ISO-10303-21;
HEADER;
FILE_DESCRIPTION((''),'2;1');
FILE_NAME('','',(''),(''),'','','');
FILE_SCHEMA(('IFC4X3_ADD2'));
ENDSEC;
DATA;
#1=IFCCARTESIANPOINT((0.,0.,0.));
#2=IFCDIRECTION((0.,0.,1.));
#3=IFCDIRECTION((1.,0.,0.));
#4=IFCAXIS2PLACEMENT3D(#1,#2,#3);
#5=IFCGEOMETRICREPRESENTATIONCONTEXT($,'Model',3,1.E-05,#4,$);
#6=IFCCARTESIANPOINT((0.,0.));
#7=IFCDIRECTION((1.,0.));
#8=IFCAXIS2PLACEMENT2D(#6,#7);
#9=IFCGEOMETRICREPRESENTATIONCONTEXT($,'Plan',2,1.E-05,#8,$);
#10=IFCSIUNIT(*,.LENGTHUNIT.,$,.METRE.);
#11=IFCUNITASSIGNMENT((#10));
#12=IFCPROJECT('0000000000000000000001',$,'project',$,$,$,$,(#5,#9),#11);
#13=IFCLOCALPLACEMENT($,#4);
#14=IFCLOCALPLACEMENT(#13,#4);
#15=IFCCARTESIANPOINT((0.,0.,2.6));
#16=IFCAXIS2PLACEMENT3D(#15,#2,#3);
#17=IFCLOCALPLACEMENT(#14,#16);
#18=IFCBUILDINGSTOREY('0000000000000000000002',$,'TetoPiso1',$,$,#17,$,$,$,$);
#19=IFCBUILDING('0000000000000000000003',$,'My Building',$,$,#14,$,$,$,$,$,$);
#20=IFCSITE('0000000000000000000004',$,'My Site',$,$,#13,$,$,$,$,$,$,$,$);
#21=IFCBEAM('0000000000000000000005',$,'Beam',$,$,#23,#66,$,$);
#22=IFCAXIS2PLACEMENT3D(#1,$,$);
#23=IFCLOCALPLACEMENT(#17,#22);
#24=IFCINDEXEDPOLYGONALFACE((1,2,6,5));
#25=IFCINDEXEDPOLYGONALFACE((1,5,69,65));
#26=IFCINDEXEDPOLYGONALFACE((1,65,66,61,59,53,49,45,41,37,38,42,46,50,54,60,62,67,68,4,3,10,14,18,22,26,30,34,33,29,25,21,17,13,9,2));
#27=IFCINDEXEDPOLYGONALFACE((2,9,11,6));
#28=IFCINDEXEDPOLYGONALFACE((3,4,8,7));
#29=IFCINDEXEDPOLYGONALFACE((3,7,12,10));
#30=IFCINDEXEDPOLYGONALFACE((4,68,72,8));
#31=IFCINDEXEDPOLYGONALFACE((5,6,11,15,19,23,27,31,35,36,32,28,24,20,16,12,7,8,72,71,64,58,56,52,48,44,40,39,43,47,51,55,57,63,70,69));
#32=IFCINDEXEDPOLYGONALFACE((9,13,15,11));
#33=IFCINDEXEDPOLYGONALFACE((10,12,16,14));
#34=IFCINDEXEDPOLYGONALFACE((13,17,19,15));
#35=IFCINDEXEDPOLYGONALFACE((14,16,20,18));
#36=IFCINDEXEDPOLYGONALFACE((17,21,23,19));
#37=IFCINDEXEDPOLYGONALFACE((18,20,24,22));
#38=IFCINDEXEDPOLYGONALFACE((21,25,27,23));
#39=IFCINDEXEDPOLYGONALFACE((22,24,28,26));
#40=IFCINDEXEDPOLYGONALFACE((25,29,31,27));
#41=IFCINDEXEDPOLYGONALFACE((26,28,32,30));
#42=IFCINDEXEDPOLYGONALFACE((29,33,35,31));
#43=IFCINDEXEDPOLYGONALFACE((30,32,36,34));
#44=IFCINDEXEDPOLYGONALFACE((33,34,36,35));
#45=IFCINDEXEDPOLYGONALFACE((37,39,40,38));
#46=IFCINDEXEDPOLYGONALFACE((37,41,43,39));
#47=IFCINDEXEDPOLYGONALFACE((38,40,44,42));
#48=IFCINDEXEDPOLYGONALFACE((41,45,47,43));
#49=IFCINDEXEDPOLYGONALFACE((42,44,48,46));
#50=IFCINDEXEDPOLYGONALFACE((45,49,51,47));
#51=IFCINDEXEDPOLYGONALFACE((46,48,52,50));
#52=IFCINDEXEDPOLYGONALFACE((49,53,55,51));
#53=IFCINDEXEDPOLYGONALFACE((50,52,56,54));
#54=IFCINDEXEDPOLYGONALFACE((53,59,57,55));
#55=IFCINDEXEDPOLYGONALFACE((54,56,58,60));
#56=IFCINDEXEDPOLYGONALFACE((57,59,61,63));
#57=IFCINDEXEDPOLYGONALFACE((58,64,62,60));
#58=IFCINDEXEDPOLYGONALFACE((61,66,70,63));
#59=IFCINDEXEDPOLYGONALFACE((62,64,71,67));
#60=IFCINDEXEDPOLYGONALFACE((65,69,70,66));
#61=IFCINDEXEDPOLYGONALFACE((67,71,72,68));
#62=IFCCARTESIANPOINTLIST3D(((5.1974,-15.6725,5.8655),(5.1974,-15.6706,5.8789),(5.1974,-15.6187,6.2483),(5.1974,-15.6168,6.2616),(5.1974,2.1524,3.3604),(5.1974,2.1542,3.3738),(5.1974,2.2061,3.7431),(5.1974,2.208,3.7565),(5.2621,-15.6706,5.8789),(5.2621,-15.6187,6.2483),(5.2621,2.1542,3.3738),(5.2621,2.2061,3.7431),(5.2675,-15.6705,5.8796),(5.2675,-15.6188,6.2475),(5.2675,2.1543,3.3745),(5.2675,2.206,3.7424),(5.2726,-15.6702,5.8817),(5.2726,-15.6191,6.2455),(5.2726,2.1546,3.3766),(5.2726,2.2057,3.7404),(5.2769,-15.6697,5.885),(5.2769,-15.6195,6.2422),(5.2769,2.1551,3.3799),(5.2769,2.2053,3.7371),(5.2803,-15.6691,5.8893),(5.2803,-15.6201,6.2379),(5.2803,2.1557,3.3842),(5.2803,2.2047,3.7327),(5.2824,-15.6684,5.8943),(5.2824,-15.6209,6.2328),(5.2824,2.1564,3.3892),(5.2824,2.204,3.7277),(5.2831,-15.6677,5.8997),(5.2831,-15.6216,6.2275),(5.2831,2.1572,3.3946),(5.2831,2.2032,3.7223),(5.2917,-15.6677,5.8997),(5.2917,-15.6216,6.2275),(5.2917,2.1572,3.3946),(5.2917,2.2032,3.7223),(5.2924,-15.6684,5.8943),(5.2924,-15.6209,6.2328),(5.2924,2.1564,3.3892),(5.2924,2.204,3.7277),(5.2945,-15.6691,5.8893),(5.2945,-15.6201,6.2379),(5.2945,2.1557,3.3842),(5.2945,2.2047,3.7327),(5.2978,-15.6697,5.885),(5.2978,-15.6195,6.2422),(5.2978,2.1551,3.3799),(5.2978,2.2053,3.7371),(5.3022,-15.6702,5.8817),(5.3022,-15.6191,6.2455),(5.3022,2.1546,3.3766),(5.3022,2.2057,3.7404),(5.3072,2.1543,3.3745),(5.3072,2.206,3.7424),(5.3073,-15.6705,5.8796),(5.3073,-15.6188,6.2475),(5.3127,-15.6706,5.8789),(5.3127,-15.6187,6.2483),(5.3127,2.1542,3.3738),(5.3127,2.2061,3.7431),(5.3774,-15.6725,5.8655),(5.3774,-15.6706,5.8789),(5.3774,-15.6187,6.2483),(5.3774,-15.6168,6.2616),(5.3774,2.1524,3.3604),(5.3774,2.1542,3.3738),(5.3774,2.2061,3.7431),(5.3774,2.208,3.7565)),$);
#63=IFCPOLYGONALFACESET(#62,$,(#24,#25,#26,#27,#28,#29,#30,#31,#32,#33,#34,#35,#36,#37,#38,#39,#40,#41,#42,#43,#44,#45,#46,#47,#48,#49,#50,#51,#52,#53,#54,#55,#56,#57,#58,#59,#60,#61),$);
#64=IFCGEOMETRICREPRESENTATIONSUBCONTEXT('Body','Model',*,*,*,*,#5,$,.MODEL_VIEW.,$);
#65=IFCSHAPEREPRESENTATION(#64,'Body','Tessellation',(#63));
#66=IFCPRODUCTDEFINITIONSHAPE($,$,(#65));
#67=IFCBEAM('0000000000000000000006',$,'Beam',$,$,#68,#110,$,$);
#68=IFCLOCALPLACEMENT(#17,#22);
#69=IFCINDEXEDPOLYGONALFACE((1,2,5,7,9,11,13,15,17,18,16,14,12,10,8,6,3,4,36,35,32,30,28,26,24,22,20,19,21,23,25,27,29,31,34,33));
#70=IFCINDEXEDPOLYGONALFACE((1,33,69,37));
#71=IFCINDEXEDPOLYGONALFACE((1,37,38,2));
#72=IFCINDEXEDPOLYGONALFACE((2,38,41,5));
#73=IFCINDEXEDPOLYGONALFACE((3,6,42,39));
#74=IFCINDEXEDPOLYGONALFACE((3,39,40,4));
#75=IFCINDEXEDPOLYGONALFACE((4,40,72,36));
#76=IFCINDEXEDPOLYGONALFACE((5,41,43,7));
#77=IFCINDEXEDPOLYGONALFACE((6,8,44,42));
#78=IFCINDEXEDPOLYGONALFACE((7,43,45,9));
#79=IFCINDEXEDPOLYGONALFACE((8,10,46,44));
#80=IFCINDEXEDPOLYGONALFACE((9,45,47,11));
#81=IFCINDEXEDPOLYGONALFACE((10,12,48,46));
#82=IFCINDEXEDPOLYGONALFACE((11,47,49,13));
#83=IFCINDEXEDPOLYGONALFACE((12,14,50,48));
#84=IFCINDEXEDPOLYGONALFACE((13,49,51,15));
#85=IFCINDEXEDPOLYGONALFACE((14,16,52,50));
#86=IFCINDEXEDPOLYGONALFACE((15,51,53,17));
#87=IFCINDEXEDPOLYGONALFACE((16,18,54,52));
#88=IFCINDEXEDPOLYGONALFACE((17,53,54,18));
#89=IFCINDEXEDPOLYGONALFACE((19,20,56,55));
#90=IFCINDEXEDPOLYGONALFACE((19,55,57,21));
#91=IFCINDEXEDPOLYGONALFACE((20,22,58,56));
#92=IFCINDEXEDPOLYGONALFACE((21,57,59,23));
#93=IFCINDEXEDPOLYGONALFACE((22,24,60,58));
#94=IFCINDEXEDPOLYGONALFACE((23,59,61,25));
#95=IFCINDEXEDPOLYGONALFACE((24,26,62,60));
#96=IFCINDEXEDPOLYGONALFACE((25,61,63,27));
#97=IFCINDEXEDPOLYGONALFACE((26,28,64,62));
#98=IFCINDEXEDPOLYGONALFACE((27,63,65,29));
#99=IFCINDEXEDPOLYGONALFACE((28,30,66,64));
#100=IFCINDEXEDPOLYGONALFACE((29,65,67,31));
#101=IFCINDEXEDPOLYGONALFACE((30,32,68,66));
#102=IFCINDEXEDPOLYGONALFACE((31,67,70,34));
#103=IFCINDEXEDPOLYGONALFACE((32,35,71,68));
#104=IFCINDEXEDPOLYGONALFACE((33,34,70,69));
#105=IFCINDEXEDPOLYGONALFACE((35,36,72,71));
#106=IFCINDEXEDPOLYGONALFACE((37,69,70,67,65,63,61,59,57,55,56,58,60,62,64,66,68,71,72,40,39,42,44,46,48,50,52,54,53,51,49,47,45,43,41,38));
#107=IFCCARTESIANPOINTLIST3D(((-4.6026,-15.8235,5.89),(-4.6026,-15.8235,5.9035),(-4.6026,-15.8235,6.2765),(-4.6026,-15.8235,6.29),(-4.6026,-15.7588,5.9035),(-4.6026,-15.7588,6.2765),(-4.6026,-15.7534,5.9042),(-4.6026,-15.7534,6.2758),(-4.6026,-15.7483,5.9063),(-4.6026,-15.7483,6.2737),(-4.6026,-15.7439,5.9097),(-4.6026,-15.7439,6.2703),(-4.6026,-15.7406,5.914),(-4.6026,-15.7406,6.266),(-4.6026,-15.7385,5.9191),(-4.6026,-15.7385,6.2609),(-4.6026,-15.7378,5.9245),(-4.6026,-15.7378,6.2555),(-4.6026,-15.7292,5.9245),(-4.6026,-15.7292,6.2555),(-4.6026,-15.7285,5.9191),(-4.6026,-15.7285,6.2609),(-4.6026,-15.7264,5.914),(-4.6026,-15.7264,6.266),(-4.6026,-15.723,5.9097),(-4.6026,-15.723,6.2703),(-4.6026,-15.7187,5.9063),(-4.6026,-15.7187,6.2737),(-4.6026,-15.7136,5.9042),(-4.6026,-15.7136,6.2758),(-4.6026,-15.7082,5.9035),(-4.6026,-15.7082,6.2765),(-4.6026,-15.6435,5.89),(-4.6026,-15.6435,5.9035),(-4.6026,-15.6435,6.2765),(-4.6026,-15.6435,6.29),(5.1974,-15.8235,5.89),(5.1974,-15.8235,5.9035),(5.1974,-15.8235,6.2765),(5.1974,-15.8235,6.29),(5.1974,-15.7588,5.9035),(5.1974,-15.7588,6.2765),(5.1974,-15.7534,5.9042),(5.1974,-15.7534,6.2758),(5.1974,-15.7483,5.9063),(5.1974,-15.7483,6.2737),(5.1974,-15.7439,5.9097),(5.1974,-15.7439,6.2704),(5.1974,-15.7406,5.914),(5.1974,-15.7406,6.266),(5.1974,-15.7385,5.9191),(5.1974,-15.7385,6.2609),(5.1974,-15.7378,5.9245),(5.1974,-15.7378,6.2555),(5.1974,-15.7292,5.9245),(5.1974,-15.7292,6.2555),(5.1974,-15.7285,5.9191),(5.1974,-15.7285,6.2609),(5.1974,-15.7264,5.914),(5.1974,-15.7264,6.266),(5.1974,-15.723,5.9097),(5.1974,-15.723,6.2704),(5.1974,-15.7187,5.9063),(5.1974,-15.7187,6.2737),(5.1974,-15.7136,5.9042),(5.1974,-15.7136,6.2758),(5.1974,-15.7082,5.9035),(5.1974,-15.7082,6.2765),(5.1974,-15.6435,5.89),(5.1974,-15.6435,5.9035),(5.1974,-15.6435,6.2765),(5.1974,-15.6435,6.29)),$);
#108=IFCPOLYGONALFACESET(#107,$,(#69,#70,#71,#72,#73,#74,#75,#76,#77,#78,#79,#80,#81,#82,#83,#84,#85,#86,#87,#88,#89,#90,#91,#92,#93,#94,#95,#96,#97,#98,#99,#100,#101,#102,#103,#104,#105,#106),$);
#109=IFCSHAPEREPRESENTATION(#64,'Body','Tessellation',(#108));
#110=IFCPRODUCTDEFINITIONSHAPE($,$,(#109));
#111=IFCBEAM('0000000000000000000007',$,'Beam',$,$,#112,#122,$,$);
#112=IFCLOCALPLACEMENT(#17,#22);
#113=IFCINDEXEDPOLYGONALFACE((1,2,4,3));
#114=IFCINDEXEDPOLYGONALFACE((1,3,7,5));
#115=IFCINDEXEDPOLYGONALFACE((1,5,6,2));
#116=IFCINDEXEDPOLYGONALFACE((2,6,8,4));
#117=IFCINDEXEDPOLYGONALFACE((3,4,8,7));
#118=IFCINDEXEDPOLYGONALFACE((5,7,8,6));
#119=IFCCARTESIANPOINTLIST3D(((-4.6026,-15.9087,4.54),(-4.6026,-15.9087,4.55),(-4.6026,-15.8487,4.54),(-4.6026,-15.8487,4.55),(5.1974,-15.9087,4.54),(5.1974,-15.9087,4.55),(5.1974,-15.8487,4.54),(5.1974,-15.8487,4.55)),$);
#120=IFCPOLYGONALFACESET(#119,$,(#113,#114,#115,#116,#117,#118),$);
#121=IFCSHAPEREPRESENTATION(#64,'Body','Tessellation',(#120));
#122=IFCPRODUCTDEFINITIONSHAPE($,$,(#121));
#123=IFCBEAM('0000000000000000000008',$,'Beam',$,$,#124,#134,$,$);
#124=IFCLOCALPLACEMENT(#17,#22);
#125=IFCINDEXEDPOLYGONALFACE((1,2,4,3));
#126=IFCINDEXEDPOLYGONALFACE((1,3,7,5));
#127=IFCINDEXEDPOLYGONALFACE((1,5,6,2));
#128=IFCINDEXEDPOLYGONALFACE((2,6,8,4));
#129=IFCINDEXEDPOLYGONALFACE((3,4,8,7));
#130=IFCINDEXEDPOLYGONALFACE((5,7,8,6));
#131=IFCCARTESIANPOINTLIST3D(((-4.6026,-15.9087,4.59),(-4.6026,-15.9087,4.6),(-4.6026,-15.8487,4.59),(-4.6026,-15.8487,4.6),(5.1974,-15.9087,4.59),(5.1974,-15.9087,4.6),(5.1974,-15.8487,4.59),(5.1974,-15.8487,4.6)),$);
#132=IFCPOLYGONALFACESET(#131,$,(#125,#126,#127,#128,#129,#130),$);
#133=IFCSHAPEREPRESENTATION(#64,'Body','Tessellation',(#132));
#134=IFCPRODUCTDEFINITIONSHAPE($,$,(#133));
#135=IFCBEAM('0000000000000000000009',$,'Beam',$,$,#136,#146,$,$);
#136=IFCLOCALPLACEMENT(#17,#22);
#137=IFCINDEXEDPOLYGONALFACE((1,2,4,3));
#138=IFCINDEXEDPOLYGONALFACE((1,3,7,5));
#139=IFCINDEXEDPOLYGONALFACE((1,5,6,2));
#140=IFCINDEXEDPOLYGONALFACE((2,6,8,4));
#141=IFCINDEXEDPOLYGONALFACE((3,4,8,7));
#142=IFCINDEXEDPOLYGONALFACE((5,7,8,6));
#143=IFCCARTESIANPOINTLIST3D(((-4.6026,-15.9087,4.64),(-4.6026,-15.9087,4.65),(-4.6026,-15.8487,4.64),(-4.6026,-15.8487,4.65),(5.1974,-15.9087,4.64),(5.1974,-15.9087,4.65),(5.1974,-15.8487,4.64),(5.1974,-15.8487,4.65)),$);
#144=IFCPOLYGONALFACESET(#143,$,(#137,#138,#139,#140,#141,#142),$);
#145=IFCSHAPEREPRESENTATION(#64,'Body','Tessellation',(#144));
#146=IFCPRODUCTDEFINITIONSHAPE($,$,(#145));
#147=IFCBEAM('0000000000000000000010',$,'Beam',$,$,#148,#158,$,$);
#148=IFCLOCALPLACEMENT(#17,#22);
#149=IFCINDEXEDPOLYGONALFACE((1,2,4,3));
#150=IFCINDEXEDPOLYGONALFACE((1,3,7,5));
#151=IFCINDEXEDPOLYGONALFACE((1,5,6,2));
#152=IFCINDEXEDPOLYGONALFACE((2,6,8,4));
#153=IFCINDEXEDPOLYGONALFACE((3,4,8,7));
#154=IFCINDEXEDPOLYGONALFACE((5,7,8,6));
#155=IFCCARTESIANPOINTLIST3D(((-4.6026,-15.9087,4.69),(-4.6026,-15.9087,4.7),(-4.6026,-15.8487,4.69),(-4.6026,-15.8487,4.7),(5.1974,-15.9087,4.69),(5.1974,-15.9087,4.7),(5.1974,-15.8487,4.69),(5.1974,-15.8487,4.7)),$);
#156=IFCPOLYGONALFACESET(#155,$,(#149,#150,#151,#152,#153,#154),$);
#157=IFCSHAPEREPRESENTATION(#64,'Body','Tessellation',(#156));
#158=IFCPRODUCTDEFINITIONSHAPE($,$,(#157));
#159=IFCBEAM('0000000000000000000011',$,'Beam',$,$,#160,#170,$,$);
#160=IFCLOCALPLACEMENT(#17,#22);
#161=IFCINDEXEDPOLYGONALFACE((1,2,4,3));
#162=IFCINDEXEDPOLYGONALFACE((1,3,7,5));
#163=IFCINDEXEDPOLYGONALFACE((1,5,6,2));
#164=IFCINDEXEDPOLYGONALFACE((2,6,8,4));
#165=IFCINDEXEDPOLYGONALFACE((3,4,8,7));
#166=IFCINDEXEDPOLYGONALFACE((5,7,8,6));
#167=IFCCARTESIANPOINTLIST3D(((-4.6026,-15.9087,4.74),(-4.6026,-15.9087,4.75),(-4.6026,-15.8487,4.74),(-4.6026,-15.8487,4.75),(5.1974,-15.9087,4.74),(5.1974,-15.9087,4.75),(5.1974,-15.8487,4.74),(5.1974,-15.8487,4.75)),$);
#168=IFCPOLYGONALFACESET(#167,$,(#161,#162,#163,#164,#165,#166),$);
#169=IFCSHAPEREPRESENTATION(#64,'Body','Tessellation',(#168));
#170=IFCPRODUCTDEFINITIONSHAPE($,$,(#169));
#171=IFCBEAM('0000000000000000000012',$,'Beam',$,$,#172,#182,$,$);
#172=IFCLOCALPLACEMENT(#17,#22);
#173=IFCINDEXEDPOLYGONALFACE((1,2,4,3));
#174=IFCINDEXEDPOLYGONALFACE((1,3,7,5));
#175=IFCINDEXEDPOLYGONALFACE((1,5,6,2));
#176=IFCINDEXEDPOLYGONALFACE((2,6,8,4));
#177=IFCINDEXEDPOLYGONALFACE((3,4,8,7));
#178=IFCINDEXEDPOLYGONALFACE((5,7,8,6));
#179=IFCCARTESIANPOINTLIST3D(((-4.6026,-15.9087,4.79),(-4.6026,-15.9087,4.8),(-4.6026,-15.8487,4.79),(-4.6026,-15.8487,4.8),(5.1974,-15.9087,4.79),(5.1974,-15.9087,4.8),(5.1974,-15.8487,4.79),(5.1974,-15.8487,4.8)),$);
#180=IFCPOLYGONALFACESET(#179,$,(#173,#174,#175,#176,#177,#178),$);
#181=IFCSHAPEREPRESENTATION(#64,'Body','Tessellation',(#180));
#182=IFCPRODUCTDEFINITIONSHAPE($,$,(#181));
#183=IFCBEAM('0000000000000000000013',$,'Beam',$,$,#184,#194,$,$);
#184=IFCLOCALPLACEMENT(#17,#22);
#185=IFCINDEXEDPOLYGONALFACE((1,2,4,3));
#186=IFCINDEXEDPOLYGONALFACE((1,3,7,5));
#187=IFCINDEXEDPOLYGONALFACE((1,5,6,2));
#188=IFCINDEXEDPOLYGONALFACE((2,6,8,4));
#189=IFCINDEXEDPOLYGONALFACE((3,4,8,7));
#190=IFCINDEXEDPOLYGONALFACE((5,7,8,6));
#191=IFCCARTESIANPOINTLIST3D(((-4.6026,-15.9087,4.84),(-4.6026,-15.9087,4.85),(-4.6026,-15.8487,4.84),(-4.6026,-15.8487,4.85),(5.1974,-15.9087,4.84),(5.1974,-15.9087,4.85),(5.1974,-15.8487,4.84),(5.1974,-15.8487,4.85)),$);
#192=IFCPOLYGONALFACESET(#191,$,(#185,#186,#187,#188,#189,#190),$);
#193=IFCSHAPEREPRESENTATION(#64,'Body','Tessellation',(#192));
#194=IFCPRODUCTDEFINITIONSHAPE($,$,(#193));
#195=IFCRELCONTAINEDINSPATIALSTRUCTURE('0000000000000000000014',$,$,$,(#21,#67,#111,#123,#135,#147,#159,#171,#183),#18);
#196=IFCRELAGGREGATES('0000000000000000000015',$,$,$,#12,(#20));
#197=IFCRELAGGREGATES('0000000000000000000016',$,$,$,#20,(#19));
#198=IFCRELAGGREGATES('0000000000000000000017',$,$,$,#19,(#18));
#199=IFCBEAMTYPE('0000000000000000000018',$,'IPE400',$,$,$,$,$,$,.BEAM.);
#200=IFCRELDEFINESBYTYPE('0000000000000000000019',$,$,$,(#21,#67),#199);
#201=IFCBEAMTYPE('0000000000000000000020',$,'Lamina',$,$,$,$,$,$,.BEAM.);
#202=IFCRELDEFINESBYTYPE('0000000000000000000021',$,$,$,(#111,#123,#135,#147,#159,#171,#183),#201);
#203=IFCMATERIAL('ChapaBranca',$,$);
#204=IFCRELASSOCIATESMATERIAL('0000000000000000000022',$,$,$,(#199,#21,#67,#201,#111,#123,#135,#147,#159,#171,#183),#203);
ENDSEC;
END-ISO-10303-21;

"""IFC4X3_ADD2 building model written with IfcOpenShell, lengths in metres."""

from ifc_helpers import new_model, si_unit, frame, origin_with_axes, origin_2d, origin_2d_with_axis, place, context, subcontext, project, spatial, rectangle, i_section, extrude, material, material_profile, profile_set, profile_usage, type_object, element, save


model = new_model("IFC4X3_ADD2")

# Units and contexts
model_context = context("Model", 3, precision=1e-05, world=origin_with_axes())
plan_context = context("Plan", 2, precision=1e-05, world=origin_2d_with_axis())
body_context_1 = subcontext(model_context, "Body", "Model", "MODEL_VIEW")
ifc_project = project(units=[si_unit("LENGTHUNIT", "METRE")], contexts=[model_context, plan_context])

# Site, building, storey
site_placement = place(None, origin_with_axes())
site = spatial("IfcSite", under=ifc_project, at=site_placement, Name="My Site")
building_placement = place(site_placement, origin_with_axes())
building = spatial("IfcBuilding", under=site, at=building_placement, Name="My Building")
storey_placement = place(building_placement, frame((0.0, 0.0, 2.6), z_axis=(0.0, 0.0, 1.0), x_axis=(1.0, 0.0, 0.0)))
storey = spatial("IfcBuildingStorey", under=building, at=storey_placement, Name="TetoPiso1")

# Beams
ifc_material_1 = material(Name="ChapaBranca")
ifc_material_profile_1 = material_profile(ifc_material_1, i_section(OverallWidth=0.18, OverallDepth=0.4, WebThickness=0.0086, FlangeThickness=0.0135, FilletRadius=0.021))
ifc_profile_set_1 = profile_set([ifc_material_profile_1])
ifc_profile_usage_1 = profile_usage(ifc_profile_set_1, cardinal=8)
beam_type_1 = type_object("IfcBeamType", Name="IPE400", PredefinedType="BEAM", material=ifc_profile_set_1)
beam_1_placement = place(storey_placement, frame((5.2874, -15.6168, 6.2616), z_axis=(0.0, 0.990268, -0.139173), x_axis=(-1.0, 0.0, 0.0)))
element("IfcBeam", 1, at=beam_1_placement, inside=storey, type_object=beam_type_1, material=ifc_profile_usage_1, Name="Beam", context=body_context_1, shape_type="SweptSolid", body=[
    extrude(i_section(OverallWidth=0.18, OverallDepth=0.4, WebThickness=0.0086, FlangeThickness=0.0135, FilletRadius=0.021), frame((0.0, -0.2, 0.0), z_axis=(0.0, 0.0, 1.0), x_axis=(1.0, 0.0, 0.0)), (0.0, 0.0, 1.0), 18.0),
])
ifc_profile_usage_2 = profile_usage(ifc_profile_set_1, cardinal=8)
beam_2_placement = place(storey_placement, frame((-4.6026, -15.7335, 6.29), z_axis=(1.0, -0.000001, 0.000001), x_axis=(0.000001, 1.0, 0.0)))
element("IfcBeam", 2, at=beam_2_placement, inside=storey, type_object=beam_type_1, material=ifc_profile_usage_2, Name="Beam", context=body_context_1, shape_type="SweptSolid", body=[
    extrude(i_section(OverallWidth=0.18, OverallDepth=0.4, WebThickness=0.0086, FlangeThickness=0.0135, FilletRadius=0.021), frame((0.0, -0.2, 0.0), z_axis=(0.0, 0.0, 1.0), x_axis=(1.0, 0.0, 0.0)), (0.0, 0.0, 1.0), 9.8),
])
ifc_material_profile_2 = material_profile(ifc_material_1, rectangle(XDim=0.06, YDim=0.01, at=origin_2d()))
ifc_profile_set_2 = profile_set([ifc_material_profile_2])
ifc_profile_usage_3 = profile_usage(ifc_profile_set_2, cardinal=5)
beam_type_2 = type_object("IfcBeamType", Name="Lamina", PredefinedType="BEAM", material=ifc_profile_set_2)
beam_3_placement = place(storey_placement, frame((-4.6026, -15.8787, 4.545), z_axis=(1.0, 0.0, 0.0), x_axis=(0.0, 1.0, 0.0)))
element("IfcBeam", 3, at=beam_3_placement, inside=storey, type_object=beam_type_2, material=ifc_profile_usage_3, Name="Beam", context=body_context_1, shape_type="SweptSolid", body=[
    extrude(rectangle(XDim=0.06, YDim=0.01, at=origin_2d()), origin_with_axes(), (0.0, 0.0, 1.0), 9.8),
])
ifc_profile_usage_4 = profile_usage(ifc_profile_set_2, cardinal=5)
beam_4_placement = place(storey_placement, frame((-4.6026, -15.8787, 4.595), z_axis=(1.0, 0.0, 0.0), x_axis=(0.0, 1.0, 0.0)))
element("IfcBeam", 4, at=beam_4_placement, inside=storey, type_object=beam_type_2, material=ifc_profile_usage_4, Name="Beam", context=body_context_1, shape_type="SweptSolid", body=[
    extrude(rectangle(XDim=0.06, YDim=0.01, at=origin_2d()), origin_with_axes(), (0.0, 0.0, 1.0), 9.8),
])
ifc_profile_usage_5 = profile_usage(ifc_profile_set_2, cardinal=5)
beam_5_placement = place(storey_placement, frame((-4.6026, -15.8787, 4.645), z_axis=(1.0, 0.0, 0.0), x_axis=(0.0, 1.0, 0.0)))
element("IfcBeam", 5, at=beam_5_placement, inside=storey, type_object=beam_type_2, material=ifc_profile_usage_5, Name="Beam", context=body_context_1, shape_type="SweptSolid", body=[
    extrude(rectangle(XDim=0.06, YDim=0.01, at=origin_2d()), origin_with_axes(), (0.0, 0.0, 1.0), 9.8),
])
ifc_profile_usage_6 = profile_usage(ifc_profile_set_2, cardinal=5)
beam_6_placement = place(storey_placement, frame((-4.6026, -15.8787, 4.695), z_axis=(1.0, 0.0, 0.0), x_axis=(0.0, 1.0, 0.0)))
element("IfcBeam", 6, at=beam_6_placement, inside=storey, type_object=beam_type_2, material=ifc_profile_usage_6, Name="Beam", context=body_context_1, shape_type="SweptSolid", body=[
    extrude(rectangle(XDim=0.06, YDim=0.01, at=origin_2d()), origin_with_axes(), (0.0, 0.0, 1.0), 9.8),
])
ifc_profile_usage_7 = profile_usage(ifc_profile_set_2, cardinal=5)
beam_7_placement = place(storey_placement, frame((-4.6026, -15.8787, 4.745), z_axis=(1.0, 0.0, 0.0), x_axis=(0.0, 1.0, 0.0)))
element("IfcBeam", 7, at=beam_7_placement, inside=storey, type_object=beam_type_2, material=ifc_profile_usage_7, Name="Beam", context=body_context_1, shape_type="SweptSolid", body=[
    extrude(rectangle(XDim=0.06, YDim=0.01, at=origin_2d()), origin_with_axes(), (0.0, 0.0, 1.0), 9.8),
])
ifc_profile_usage_8 = profile_usage(ifc_profile_set_2, cardinal=5)
beam_8_placement = place(storey_placement, frame((-4.6026, -15.8787, 4.795), z_axis=(1.0, 0.0, 0.0), x_axis=(0.0, 1.0, 0.0)))
element("IfcBeam", 8, at=beam_8_placement, inside=storey, type_object=beam_type_2, material=ifc_profile_usage_8, Name="Beam", context=body_context_1, shape_type="SweptSolid", body=[
    extrude(rectangle(XDim=0.06, YDim=0.01, at=origin_2d()), origin_with_axes(), (0.0, 0.0, 1.0), 9.8),
])
ifc_profile_usage_9 = profile_usage(ifc_profile_set_2, cardinal=5)
beam_9_placement = place(storey_placement, frame((-4.6026, -15.8787, 4.845), z_axis=(1.0, 0.0, 0.0), x_axis=(0.0, 1.0, 0.0)))
element("IfcBeam", 9, at=beam_9_placement, inside=storey, type_object=beam_type_2, material=ifc_profile_usage_9, Name="Beam", context=body_context_1, shape_type="SweptSolid", body=[
    extrude(rectangle(XDim=0.06, YDim=0.01, at=origin_2d()), origin_with_axes(), (0.0, 0.0, 1.0), 9.8),
])

save(model, "model.ifc")
